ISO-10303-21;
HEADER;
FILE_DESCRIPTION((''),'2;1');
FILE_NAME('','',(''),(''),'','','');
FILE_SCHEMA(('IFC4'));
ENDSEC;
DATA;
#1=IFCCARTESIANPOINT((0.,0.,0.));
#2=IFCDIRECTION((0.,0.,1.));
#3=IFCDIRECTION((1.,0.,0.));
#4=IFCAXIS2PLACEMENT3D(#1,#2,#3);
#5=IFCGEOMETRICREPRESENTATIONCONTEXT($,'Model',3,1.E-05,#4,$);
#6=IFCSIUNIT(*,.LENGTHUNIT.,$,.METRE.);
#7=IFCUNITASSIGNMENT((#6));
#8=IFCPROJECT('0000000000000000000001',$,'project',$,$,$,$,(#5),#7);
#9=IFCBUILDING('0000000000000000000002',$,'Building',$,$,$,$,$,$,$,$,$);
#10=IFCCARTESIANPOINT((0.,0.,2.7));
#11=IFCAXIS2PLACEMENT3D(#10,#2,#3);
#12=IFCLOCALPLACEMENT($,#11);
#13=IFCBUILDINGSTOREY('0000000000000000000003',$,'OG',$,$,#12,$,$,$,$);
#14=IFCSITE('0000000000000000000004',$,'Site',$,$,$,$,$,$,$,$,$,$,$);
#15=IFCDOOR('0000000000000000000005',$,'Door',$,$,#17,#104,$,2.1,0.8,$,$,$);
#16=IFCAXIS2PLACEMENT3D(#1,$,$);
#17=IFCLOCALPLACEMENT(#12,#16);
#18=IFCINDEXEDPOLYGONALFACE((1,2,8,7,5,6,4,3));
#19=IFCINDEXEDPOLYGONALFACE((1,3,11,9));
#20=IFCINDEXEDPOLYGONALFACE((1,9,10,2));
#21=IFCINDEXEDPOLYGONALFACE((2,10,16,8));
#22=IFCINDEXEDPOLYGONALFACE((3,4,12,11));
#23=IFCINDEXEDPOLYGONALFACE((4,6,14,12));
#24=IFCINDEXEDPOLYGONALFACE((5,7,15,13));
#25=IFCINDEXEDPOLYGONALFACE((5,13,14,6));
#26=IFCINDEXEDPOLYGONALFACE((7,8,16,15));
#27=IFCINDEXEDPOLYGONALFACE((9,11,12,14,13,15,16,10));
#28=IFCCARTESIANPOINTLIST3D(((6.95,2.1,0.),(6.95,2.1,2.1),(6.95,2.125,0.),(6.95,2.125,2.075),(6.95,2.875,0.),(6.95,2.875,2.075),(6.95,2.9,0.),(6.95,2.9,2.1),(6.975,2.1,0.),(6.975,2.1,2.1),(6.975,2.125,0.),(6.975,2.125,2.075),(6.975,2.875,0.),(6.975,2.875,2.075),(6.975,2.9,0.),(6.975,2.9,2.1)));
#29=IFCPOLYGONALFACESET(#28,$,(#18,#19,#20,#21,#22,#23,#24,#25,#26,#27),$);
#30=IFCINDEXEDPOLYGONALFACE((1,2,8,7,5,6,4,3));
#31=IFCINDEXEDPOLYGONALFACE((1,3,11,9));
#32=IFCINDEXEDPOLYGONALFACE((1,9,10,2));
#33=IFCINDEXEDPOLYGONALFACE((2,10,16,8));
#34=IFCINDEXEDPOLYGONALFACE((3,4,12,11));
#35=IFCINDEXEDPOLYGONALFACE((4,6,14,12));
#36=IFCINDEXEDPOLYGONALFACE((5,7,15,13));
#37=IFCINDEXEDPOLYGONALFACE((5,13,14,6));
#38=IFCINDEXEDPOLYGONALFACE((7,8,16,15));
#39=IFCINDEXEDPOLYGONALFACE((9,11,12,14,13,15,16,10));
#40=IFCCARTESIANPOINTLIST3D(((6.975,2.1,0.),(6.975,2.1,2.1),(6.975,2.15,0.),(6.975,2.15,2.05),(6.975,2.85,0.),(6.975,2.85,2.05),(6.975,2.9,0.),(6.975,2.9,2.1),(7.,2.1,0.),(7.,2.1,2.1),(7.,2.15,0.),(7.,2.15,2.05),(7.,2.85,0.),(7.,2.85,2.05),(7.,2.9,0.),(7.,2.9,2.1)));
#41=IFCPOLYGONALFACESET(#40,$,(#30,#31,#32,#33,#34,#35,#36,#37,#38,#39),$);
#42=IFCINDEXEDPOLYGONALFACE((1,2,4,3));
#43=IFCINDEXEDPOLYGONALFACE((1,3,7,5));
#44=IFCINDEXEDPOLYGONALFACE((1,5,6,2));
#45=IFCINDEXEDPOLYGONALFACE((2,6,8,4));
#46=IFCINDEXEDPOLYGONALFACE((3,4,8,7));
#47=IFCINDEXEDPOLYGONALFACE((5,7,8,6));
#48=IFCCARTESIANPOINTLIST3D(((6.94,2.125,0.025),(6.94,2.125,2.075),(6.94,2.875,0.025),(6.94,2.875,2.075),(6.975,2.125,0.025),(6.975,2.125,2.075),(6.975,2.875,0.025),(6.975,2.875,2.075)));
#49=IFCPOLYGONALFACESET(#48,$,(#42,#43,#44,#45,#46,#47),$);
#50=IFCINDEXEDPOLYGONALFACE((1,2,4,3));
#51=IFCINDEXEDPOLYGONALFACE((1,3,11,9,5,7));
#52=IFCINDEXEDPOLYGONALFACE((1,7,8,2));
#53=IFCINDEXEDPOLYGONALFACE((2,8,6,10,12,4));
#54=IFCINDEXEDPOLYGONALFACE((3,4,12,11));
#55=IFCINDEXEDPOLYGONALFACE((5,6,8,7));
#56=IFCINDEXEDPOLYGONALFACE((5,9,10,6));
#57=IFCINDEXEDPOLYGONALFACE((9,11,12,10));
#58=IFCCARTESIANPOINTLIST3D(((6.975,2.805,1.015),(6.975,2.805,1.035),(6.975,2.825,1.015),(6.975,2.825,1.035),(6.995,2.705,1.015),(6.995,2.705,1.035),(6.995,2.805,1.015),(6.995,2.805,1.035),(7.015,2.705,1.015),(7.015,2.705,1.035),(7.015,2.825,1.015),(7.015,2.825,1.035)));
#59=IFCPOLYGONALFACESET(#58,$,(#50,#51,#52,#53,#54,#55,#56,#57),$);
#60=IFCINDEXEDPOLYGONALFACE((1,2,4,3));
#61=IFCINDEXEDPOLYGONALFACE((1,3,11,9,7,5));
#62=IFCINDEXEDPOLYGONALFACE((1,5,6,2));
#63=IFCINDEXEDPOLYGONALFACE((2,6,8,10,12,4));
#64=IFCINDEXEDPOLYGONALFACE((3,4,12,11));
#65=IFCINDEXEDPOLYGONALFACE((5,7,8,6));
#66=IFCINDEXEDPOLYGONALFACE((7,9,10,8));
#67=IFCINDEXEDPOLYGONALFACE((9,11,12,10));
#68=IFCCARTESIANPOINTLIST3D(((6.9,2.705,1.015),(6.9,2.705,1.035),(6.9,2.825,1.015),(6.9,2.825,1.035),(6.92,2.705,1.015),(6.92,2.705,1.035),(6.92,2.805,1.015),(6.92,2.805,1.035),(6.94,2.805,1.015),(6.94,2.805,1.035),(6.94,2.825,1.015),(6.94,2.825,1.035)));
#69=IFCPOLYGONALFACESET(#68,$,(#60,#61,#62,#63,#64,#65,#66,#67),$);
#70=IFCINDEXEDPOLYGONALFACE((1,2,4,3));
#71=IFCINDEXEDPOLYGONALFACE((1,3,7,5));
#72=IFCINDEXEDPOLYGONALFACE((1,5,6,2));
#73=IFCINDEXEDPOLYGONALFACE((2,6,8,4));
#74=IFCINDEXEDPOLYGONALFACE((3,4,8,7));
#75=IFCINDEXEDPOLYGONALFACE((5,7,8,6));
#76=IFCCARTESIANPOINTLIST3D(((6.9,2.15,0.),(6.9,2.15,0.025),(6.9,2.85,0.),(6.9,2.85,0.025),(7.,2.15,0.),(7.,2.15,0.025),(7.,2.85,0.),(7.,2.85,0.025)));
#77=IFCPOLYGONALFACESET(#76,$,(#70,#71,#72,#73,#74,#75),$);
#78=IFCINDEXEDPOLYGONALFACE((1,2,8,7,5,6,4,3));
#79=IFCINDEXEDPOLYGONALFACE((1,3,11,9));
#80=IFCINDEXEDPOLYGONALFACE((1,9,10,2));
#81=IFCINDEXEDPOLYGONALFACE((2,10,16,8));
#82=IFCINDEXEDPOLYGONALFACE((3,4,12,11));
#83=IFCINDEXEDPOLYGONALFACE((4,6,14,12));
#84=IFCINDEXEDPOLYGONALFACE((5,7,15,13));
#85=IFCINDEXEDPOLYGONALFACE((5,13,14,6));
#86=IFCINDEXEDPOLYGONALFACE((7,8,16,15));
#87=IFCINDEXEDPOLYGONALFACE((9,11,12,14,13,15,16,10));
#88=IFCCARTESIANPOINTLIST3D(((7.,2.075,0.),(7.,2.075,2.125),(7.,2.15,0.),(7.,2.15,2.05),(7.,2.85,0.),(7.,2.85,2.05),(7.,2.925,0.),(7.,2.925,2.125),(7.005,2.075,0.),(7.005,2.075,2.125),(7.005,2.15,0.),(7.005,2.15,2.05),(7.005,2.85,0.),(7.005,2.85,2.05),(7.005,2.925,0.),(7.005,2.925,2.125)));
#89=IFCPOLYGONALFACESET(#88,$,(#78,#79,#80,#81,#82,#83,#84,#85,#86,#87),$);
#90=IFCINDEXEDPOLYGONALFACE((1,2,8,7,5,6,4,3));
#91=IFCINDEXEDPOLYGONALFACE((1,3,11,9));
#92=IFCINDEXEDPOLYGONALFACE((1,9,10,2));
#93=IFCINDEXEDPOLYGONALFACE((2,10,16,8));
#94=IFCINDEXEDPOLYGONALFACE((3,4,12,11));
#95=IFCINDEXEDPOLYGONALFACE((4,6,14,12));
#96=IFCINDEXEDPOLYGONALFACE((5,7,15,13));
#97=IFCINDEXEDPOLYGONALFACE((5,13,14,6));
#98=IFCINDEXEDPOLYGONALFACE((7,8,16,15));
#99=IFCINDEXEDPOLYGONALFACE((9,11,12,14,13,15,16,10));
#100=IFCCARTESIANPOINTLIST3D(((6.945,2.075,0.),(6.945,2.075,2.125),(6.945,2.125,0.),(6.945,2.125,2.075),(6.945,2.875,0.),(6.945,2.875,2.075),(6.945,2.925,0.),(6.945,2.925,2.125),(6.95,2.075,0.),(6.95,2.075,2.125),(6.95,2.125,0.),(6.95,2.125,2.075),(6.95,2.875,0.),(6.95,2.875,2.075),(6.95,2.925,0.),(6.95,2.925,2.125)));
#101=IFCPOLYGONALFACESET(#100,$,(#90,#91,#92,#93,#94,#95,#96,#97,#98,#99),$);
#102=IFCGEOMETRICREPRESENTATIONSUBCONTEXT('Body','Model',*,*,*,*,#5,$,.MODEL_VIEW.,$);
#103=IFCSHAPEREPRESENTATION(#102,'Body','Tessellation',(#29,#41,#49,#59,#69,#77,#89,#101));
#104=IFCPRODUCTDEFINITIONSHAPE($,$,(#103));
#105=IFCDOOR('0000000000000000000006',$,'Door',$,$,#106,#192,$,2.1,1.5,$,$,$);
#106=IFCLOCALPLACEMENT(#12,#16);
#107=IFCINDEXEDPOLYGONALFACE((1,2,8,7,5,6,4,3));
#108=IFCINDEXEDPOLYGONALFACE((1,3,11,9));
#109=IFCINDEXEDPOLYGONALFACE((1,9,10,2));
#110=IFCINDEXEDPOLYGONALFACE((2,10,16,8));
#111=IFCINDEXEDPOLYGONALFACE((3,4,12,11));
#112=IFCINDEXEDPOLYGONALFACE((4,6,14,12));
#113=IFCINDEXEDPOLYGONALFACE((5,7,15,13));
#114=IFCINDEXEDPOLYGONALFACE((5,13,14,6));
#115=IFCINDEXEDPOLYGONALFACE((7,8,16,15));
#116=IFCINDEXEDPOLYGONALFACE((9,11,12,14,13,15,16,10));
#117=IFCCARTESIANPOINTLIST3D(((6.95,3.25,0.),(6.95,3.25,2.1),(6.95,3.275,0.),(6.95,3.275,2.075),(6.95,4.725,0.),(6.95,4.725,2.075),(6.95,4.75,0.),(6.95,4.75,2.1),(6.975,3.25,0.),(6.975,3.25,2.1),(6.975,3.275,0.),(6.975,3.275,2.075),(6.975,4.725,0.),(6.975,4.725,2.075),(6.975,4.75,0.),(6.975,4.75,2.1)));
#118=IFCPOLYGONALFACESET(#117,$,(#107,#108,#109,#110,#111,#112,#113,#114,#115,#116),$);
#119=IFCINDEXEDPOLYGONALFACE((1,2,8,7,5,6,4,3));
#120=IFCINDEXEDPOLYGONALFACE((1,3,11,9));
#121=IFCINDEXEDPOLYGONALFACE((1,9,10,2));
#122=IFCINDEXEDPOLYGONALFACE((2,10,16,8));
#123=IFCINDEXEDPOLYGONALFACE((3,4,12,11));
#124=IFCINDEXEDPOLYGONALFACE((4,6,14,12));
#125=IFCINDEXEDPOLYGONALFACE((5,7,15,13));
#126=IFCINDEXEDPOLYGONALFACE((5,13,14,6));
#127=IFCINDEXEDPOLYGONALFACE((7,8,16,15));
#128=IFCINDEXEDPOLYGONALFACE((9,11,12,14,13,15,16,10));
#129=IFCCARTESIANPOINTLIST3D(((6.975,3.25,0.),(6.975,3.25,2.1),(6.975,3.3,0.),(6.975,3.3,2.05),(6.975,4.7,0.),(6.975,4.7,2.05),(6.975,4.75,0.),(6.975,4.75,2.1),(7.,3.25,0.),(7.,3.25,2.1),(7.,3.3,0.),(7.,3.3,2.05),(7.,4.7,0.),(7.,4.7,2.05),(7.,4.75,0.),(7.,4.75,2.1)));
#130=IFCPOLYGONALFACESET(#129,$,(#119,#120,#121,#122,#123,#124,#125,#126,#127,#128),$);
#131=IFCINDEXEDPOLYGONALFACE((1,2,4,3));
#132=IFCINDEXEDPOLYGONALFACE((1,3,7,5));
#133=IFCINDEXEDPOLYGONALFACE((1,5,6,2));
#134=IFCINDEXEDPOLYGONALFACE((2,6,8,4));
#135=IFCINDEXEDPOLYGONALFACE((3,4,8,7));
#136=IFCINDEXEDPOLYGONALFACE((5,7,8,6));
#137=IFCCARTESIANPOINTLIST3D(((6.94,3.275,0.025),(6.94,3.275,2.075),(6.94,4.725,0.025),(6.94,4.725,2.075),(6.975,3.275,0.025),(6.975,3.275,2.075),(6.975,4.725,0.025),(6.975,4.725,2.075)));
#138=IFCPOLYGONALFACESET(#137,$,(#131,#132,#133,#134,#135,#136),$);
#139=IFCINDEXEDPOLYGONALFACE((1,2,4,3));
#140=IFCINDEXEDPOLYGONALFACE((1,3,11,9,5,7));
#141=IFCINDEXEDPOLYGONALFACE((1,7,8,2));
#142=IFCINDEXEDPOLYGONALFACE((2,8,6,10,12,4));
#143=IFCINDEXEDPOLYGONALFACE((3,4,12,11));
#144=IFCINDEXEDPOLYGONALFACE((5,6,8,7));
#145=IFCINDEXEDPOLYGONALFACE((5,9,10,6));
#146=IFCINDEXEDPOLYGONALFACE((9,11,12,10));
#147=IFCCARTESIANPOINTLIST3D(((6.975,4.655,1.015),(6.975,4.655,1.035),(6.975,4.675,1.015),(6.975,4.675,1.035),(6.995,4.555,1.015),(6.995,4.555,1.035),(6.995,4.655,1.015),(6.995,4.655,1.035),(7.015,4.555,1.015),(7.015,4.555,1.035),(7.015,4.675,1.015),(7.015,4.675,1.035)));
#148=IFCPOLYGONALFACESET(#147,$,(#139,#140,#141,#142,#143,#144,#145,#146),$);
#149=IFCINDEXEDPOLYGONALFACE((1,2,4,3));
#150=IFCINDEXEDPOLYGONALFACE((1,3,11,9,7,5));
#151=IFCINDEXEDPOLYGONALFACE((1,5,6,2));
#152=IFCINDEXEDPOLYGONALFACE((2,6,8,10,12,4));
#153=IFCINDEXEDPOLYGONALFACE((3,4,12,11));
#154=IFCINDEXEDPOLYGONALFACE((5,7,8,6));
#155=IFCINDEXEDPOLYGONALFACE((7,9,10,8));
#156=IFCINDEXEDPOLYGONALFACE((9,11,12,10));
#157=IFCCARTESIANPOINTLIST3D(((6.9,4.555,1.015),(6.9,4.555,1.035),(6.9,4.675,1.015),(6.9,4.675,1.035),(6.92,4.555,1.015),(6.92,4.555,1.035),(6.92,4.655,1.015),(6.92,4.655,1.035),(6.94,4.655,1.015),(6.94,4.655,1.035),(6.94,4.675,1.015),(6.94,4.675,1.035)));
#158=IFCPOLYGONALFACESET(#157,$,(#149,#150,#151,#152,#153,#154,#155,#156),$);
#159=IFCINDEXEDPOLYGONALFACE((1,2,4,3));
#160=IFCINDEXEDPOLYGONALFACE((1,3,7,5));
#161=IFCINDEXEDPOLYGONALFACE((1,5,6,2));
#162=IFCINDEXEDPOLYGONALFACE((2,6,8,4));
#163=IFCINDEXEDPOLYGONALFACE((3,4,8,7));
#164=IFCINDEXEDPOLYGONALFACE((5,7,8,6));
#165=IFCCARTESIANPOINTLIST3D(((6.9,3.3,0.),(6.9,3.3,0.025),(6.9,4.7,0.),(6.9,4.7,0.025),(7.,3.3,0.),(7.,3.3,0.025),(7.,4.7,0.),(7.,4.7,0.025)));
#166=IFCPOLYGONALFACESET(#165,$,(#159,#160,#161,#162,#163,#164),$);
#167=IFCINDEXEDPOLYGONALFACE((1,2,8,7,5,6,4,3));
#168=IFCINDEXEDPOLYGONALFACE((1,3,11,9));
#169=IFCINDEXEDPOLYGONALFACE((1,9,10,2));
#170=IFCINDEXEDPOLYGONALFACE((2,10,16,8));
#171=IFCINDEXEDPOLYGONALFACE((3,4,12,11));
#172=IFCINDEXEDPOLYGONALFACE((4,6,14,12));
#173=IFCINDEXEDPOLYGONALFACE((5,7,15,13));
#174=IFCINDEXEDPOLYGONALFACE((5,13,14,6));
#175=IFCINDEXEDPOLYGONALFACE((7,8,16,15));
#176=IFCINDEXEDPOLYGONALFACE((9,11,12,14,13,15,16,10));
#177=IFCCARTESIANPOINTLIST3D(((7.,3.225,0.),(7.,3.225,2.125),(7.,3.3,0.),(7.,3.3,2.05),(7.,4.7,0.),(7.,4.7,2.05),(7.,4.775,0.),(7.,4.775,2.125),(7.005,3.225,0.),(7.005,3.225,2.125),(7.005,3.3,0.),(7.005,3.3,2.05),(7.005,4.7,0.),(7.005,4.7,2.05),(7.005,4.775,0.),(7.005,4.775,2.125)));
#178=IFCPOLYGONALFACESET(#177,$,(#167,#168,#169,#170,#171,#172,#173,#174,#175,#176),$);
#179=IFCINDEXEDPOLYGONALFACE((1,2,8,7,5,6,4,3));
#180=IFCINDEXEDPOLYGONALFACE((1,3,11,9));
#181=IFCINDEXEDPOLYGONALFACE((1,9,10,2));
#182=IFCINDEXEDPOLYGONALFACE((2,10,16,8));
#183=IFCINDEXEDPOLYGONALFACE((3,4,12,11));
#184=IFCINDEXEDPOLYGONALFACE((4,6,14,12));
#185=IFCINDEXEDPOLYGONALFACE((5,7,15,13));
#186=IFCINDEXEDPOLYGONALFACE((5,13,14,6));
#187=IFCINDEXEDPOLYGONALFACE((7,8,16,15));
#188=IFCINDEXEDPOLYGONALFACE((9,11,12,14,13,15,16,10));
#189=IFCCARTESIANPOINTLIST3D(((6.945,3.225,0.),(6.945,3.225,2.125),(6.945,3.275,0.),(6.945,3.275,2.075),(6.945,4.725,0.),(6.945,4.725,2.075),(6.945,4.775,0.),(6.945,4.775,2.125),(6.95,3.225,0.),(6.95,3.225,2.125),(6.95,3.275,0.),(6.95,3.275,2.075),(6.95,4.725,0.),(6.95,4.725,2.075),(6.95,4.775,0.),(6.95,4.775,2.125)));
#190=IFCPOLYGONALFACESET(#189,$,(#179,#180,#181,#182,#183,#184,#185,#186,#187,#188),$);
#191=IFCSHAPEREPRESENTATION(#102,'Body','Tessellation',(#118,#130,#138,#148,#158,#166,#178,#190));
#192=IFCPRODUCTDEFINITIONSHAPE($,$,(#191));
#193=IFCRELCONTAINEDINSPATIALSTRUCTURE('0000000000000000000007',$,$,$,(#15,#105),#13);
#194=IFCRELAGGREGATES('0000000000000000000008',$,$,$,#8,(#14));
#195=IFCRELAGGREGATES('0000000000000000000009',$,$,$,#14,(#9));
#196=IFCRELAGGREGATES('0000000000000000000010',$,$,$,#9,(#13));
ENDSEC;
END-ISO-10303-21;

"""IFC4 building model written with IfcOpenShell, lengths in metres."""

from ifc_helpers import new_model, si_unit, frame, origin_with_axes, place, context, subcontext, project, spatial, line, indexed_curve, outline, extrude, element, save


model = new_model("IFC4")

# Units and contexts
model_context = context("Model", 3, precision=1e-05, world=origin_with_axes())
body_context = subcontext(model_context, "Body", "Model", "MODEL_VIEW")
ifc_project = project(units=[si_unit("LENGTHUNIT", "METRE")], contexts=[model_context])

# Site, building, storey
site = spatial("IfcSite", under=ifc_project, Name="Site")
building = spatial("IfcBuilding", under=site, Name="Building")
storey_placement = place(None, frame((0.0, 0.0, 2.7), z_axis=(0.0, 0.0, 1.0), x_axis=(1.0, 0.0, 0.0)))
storey = spatial("IfcBuildingStorey", under=building, at=storey_placement, Name="OG")

# Doors
door_1_placement = place(storey_placement, frame((7.0, 2.1, 0.0), z_axis=(0.0, 0.0, 1.0), x_axis=(0.0, 1.0, 0.0)))
element("IfcDoor", 1, at=door_1_placement, inside=storey, Name="Door", OverallHeight=2.1, OverallWidth=0.8, context=body_context, shape_type="SweptSolid", body=[
    extrude(outline(indexed_curve([(0.0, 0.0), (0.0, 2.1), (0.8, 2.1), (0.8, 0.0), (0.775, 0.0), (0.775, 2.075), (0.025, 2.075), (0.025, 0.0)], segments=[line(1, 2, 3, 4, 5, 6, 7, 8, 1)])), frame((0.0, 0.025, 0.0), z_axis=(0.0, -1.0, 0.0), x_axis=(1.0, 0.0, 0.0)), (0.0, 0.0, -1.0), 0.025),
    extrude(outline(indexed_curve([(0.0, 0.0), (0.0, 2.1), (0.8, 2.1), (0.8, 0.0), (0.75, 0.0), (0.75, 2.05), (0.05, 2.05), (0.05, 0.0)], segments=[line(1, 2, 3, 4, 5, 6, 7, 8, 1)])), frame((0.0, 0.0, 0.0), z_axis=(0.0, -1.0, 0.0), x_axis=(1.0, 0.0, 0.0)), (0.0, 0.0, -1.0), 0.025),
    extrude(outline(indexed_curve([(0.0, 0.0), (0.75, 0.0), (0.75, 0.035), (0.0, 0.035)], segments=[line(1, 2, 3, 4, 1)])), frame((0.025, 0.025, 0.025), z_axis=(0.0, 0.0, 1.0), x_axis=(1.0, 0.0, 0.0)), (0.0, 0.0, 1.0), 2.05),
    extrude(outline(indexed_curve([(0.0, 0.0), (0.0, -0.04), (-0.12, -0.04), (-0.12, -0.02), (-0.02, -0.02), (-0.02, 0.0)], segments=[line(1, 2, 3, 4, 5, 6, 1)])), frame((0.725, 0.025, 1.015), z_axis=(0.0, 0.0, 1.0), x_axis=(1.0, 0.0, 0.0)), (0.0, 0.0, 1.0), 0.02),
    extrude(outline(indexed_curve([(0.0, 0.0), (0.0, 0.04), (-0.12, 0.04), (-0.12, 0.02), (-0.02, 0.02), (-0.02, 0.0)], segments=[line(1, 2, 3, 4, 5, 6, 1)])), frame((0.725, 0.06, 1.015), z_axis=(0.0, 0.0, 1.0), x_axis=(1.0, 0.0, 0.0)), (0.0, 0.0, 1.0), 0.02),
    extrude(outline(indexed_curve([(0.0, 0.0), (0.7, 0.0), (0.7, 0.1), (0.0, 0.1)], segments=[line(1, 2, 3, 4, 1)])), frame((0.05, 0.0, 0.0), z_axis=(0.0, 0.0, 1.0), x_axis=(1.0, 0.0, 0.0)), (0.0, 0.0, 1.0), 0.025),
    extrude(outline(indexed_curve([(0.0, 0.0), (0.0, 2.125), (0.85, 2.125), (0.85, 0.0), (0.775, 0.0), (0.775, 2.05), (0.075, 2.05), (0.075, 0.0)], segments=[line(1, 2, 3, 4, 5, 6, 7, 8, 1)])), frame((-0.025, -0.005, 0.0), z_axis=(0.0, -1.0, 0.0), x_axis=(1.0, 0.0, 0.0)), (0.0, 0.0, -1.0), 0.005),
    extrude(outline(indexed_curve([(0.0, 0.0), (0.0, 2.125), (0.85, 2.125), (0.85, 0.0), (0.8, 0.0), (0.8, 2.075), (0.05, 2.075), (0.05, 0.0)], segments=[line(1, 2, 3, 4, 5, 6, 7, 8, 1)])), frame((-0.025, 0.05, 0.0), z_axis=(0.0, -1.0, 0.0), x_axis=(1.0, 0.0, 0.0)), (0.0, 0.0, -1.0), 0.005),
])
door_2_placement = place(storey_placement, frame((7.0, 3.25, 0.0), z_axis=(0.0, 0.0, 1.0), x_axis=(0.0, 1.0, 0.0)))
element("IfcDoor", 2, at=door_2_placement, inside=storey, Name="Door", OverallHeight=2.1, OverallWidth=1.5, context=body_context, shape_type="SweptSolid", body=[
    extrude(outline(indexed_curve([(0.0, 0.0), (0.0, 2.1), (1.5, 2.1), (1.5, 0.0), (1.475, 0.0), (1.475, 2.075), (0.025, 2.075), (0.025, 0.0)], segments=[line(1, 2, 3, 4, 5, 6, 7, 8, 1)])), frame((0.0, 0.025, 0.0), z_axis=(0.0, -1.0, 0.0), x_axis=(1.0, 0.0, 0.0)), (0.0, 0.0, -1.0), 0.025),
    extrude(outline(indexed_curve([(0.0, 0.0), (0.0, 2.1), (1.5, 2.1), (1.5, 0.0), (1.45, 0.0), (1.45, 2.05), (0.05, 2.05), (0.05, 0.0)], segments=[line(1, 2, 3, 4, 5, 6, 7, 8, 1)])), frame((0.0, 0.0, 0.0), z_axis=(0.0, -1.0, 0.0), x_axis=(1.0, 0.0, 0.0)), (0.0, 0.0, -1.0), 0.025),
    extrude(outline(indexed_curve([(0.0, 0.0), (1.45, 0.0), (1.45, 0.035), (0.0, 0.035)], segments=[line(1, 2, 3, 4, 1)])), frame((0.025, 0.025, 0.025), z_axis=(0.0, 0.0, 1.0), x_axis=(1.0, 0.0, 0.0)), (0.0, 0.0, 1.0), 2.05),
    extrude(outline(indexed_curve([(0.0, 0.0), (0.0, -0.04), (-0.12, -0.04), (-0.12, -0.02), (-0.02, -0.02), (-0.02, 0.0)], segments=[line(1, 2, 3, 4, 5, 6, 1)])), frame((1.425, 0.025, 1.015), z_axis=(0.0, 0.0, 1.0), x_axis=(1.0, 0.0, 0.0)), (0.0, 0.0, 1.0), 0.02),
    extrude(outline(indexed_curve([(0.0, 0.0), (0.0, 0.04), (-0.12, 0.04), (-0.12, 0.02), (-0.02, 0.02), (-0.02, 0.0)], segments=[line(1, 2, 3, 4, 5, 6, 1)])), frame((1.425, 0.06, 1.015), z_axis=(0.0, 0.0, 1.0), x_axis=(1.0, 0.0, 0.0)), (0.0, 0.0, 1.0), 0.02),
    extrude(outline(indexed_curve([(0.0, 0.0), (1.4, 0.0), (1.4, 0.1), (0.0, 0.1)], segments=[line(1, 2, 3, 4, 1)])), frame((0.05, 0.0, 0.0), z_axis=(0.0, 0.0, 1.0), x_axis=(1.0, 0.0, 0.0)), (0.0, 0.0, 1.0), 0.025),
    extrude(outline(indexed_curve([(0.0, 0.0), (0.0, 2.125), (1.55, 2.125), (1.55, 0.0), (1.475, 0.0), (1.475, 2.05), (0.075, 2.05), (0.075, 0.0)], segments=[line(1, 2, 3, 4, 5, 6, 7, 8, 1)])), frame((-0.025, -0.005, 0.0), z_axis=(0.0, -1.0, 0.0), x_axis=(1.0, 0.0, 0.0)), (0.0, 0.0, -1.0), 0.005),
    extrude(outline(indexed_curve([(0.0, 0.0), (0.0, 2.125), (1.55, 2.125), (1.55, 0.0), (1.5, 0.0), (1.5, 2.075), (0.05, 2.075), (0.05, 0.0)], segments=[line(1, 2, 3, 4, 5, 6, 7, 8, 1)])), frame((-0.025, 0.05, 0.0), z_axis=(0.0, -1.0, 0.0), x_axis=(1.0, 0.0, 0.0)), (0.0, 0.0, -1.0), 0.005),
])

save(model, "model.ifc")
